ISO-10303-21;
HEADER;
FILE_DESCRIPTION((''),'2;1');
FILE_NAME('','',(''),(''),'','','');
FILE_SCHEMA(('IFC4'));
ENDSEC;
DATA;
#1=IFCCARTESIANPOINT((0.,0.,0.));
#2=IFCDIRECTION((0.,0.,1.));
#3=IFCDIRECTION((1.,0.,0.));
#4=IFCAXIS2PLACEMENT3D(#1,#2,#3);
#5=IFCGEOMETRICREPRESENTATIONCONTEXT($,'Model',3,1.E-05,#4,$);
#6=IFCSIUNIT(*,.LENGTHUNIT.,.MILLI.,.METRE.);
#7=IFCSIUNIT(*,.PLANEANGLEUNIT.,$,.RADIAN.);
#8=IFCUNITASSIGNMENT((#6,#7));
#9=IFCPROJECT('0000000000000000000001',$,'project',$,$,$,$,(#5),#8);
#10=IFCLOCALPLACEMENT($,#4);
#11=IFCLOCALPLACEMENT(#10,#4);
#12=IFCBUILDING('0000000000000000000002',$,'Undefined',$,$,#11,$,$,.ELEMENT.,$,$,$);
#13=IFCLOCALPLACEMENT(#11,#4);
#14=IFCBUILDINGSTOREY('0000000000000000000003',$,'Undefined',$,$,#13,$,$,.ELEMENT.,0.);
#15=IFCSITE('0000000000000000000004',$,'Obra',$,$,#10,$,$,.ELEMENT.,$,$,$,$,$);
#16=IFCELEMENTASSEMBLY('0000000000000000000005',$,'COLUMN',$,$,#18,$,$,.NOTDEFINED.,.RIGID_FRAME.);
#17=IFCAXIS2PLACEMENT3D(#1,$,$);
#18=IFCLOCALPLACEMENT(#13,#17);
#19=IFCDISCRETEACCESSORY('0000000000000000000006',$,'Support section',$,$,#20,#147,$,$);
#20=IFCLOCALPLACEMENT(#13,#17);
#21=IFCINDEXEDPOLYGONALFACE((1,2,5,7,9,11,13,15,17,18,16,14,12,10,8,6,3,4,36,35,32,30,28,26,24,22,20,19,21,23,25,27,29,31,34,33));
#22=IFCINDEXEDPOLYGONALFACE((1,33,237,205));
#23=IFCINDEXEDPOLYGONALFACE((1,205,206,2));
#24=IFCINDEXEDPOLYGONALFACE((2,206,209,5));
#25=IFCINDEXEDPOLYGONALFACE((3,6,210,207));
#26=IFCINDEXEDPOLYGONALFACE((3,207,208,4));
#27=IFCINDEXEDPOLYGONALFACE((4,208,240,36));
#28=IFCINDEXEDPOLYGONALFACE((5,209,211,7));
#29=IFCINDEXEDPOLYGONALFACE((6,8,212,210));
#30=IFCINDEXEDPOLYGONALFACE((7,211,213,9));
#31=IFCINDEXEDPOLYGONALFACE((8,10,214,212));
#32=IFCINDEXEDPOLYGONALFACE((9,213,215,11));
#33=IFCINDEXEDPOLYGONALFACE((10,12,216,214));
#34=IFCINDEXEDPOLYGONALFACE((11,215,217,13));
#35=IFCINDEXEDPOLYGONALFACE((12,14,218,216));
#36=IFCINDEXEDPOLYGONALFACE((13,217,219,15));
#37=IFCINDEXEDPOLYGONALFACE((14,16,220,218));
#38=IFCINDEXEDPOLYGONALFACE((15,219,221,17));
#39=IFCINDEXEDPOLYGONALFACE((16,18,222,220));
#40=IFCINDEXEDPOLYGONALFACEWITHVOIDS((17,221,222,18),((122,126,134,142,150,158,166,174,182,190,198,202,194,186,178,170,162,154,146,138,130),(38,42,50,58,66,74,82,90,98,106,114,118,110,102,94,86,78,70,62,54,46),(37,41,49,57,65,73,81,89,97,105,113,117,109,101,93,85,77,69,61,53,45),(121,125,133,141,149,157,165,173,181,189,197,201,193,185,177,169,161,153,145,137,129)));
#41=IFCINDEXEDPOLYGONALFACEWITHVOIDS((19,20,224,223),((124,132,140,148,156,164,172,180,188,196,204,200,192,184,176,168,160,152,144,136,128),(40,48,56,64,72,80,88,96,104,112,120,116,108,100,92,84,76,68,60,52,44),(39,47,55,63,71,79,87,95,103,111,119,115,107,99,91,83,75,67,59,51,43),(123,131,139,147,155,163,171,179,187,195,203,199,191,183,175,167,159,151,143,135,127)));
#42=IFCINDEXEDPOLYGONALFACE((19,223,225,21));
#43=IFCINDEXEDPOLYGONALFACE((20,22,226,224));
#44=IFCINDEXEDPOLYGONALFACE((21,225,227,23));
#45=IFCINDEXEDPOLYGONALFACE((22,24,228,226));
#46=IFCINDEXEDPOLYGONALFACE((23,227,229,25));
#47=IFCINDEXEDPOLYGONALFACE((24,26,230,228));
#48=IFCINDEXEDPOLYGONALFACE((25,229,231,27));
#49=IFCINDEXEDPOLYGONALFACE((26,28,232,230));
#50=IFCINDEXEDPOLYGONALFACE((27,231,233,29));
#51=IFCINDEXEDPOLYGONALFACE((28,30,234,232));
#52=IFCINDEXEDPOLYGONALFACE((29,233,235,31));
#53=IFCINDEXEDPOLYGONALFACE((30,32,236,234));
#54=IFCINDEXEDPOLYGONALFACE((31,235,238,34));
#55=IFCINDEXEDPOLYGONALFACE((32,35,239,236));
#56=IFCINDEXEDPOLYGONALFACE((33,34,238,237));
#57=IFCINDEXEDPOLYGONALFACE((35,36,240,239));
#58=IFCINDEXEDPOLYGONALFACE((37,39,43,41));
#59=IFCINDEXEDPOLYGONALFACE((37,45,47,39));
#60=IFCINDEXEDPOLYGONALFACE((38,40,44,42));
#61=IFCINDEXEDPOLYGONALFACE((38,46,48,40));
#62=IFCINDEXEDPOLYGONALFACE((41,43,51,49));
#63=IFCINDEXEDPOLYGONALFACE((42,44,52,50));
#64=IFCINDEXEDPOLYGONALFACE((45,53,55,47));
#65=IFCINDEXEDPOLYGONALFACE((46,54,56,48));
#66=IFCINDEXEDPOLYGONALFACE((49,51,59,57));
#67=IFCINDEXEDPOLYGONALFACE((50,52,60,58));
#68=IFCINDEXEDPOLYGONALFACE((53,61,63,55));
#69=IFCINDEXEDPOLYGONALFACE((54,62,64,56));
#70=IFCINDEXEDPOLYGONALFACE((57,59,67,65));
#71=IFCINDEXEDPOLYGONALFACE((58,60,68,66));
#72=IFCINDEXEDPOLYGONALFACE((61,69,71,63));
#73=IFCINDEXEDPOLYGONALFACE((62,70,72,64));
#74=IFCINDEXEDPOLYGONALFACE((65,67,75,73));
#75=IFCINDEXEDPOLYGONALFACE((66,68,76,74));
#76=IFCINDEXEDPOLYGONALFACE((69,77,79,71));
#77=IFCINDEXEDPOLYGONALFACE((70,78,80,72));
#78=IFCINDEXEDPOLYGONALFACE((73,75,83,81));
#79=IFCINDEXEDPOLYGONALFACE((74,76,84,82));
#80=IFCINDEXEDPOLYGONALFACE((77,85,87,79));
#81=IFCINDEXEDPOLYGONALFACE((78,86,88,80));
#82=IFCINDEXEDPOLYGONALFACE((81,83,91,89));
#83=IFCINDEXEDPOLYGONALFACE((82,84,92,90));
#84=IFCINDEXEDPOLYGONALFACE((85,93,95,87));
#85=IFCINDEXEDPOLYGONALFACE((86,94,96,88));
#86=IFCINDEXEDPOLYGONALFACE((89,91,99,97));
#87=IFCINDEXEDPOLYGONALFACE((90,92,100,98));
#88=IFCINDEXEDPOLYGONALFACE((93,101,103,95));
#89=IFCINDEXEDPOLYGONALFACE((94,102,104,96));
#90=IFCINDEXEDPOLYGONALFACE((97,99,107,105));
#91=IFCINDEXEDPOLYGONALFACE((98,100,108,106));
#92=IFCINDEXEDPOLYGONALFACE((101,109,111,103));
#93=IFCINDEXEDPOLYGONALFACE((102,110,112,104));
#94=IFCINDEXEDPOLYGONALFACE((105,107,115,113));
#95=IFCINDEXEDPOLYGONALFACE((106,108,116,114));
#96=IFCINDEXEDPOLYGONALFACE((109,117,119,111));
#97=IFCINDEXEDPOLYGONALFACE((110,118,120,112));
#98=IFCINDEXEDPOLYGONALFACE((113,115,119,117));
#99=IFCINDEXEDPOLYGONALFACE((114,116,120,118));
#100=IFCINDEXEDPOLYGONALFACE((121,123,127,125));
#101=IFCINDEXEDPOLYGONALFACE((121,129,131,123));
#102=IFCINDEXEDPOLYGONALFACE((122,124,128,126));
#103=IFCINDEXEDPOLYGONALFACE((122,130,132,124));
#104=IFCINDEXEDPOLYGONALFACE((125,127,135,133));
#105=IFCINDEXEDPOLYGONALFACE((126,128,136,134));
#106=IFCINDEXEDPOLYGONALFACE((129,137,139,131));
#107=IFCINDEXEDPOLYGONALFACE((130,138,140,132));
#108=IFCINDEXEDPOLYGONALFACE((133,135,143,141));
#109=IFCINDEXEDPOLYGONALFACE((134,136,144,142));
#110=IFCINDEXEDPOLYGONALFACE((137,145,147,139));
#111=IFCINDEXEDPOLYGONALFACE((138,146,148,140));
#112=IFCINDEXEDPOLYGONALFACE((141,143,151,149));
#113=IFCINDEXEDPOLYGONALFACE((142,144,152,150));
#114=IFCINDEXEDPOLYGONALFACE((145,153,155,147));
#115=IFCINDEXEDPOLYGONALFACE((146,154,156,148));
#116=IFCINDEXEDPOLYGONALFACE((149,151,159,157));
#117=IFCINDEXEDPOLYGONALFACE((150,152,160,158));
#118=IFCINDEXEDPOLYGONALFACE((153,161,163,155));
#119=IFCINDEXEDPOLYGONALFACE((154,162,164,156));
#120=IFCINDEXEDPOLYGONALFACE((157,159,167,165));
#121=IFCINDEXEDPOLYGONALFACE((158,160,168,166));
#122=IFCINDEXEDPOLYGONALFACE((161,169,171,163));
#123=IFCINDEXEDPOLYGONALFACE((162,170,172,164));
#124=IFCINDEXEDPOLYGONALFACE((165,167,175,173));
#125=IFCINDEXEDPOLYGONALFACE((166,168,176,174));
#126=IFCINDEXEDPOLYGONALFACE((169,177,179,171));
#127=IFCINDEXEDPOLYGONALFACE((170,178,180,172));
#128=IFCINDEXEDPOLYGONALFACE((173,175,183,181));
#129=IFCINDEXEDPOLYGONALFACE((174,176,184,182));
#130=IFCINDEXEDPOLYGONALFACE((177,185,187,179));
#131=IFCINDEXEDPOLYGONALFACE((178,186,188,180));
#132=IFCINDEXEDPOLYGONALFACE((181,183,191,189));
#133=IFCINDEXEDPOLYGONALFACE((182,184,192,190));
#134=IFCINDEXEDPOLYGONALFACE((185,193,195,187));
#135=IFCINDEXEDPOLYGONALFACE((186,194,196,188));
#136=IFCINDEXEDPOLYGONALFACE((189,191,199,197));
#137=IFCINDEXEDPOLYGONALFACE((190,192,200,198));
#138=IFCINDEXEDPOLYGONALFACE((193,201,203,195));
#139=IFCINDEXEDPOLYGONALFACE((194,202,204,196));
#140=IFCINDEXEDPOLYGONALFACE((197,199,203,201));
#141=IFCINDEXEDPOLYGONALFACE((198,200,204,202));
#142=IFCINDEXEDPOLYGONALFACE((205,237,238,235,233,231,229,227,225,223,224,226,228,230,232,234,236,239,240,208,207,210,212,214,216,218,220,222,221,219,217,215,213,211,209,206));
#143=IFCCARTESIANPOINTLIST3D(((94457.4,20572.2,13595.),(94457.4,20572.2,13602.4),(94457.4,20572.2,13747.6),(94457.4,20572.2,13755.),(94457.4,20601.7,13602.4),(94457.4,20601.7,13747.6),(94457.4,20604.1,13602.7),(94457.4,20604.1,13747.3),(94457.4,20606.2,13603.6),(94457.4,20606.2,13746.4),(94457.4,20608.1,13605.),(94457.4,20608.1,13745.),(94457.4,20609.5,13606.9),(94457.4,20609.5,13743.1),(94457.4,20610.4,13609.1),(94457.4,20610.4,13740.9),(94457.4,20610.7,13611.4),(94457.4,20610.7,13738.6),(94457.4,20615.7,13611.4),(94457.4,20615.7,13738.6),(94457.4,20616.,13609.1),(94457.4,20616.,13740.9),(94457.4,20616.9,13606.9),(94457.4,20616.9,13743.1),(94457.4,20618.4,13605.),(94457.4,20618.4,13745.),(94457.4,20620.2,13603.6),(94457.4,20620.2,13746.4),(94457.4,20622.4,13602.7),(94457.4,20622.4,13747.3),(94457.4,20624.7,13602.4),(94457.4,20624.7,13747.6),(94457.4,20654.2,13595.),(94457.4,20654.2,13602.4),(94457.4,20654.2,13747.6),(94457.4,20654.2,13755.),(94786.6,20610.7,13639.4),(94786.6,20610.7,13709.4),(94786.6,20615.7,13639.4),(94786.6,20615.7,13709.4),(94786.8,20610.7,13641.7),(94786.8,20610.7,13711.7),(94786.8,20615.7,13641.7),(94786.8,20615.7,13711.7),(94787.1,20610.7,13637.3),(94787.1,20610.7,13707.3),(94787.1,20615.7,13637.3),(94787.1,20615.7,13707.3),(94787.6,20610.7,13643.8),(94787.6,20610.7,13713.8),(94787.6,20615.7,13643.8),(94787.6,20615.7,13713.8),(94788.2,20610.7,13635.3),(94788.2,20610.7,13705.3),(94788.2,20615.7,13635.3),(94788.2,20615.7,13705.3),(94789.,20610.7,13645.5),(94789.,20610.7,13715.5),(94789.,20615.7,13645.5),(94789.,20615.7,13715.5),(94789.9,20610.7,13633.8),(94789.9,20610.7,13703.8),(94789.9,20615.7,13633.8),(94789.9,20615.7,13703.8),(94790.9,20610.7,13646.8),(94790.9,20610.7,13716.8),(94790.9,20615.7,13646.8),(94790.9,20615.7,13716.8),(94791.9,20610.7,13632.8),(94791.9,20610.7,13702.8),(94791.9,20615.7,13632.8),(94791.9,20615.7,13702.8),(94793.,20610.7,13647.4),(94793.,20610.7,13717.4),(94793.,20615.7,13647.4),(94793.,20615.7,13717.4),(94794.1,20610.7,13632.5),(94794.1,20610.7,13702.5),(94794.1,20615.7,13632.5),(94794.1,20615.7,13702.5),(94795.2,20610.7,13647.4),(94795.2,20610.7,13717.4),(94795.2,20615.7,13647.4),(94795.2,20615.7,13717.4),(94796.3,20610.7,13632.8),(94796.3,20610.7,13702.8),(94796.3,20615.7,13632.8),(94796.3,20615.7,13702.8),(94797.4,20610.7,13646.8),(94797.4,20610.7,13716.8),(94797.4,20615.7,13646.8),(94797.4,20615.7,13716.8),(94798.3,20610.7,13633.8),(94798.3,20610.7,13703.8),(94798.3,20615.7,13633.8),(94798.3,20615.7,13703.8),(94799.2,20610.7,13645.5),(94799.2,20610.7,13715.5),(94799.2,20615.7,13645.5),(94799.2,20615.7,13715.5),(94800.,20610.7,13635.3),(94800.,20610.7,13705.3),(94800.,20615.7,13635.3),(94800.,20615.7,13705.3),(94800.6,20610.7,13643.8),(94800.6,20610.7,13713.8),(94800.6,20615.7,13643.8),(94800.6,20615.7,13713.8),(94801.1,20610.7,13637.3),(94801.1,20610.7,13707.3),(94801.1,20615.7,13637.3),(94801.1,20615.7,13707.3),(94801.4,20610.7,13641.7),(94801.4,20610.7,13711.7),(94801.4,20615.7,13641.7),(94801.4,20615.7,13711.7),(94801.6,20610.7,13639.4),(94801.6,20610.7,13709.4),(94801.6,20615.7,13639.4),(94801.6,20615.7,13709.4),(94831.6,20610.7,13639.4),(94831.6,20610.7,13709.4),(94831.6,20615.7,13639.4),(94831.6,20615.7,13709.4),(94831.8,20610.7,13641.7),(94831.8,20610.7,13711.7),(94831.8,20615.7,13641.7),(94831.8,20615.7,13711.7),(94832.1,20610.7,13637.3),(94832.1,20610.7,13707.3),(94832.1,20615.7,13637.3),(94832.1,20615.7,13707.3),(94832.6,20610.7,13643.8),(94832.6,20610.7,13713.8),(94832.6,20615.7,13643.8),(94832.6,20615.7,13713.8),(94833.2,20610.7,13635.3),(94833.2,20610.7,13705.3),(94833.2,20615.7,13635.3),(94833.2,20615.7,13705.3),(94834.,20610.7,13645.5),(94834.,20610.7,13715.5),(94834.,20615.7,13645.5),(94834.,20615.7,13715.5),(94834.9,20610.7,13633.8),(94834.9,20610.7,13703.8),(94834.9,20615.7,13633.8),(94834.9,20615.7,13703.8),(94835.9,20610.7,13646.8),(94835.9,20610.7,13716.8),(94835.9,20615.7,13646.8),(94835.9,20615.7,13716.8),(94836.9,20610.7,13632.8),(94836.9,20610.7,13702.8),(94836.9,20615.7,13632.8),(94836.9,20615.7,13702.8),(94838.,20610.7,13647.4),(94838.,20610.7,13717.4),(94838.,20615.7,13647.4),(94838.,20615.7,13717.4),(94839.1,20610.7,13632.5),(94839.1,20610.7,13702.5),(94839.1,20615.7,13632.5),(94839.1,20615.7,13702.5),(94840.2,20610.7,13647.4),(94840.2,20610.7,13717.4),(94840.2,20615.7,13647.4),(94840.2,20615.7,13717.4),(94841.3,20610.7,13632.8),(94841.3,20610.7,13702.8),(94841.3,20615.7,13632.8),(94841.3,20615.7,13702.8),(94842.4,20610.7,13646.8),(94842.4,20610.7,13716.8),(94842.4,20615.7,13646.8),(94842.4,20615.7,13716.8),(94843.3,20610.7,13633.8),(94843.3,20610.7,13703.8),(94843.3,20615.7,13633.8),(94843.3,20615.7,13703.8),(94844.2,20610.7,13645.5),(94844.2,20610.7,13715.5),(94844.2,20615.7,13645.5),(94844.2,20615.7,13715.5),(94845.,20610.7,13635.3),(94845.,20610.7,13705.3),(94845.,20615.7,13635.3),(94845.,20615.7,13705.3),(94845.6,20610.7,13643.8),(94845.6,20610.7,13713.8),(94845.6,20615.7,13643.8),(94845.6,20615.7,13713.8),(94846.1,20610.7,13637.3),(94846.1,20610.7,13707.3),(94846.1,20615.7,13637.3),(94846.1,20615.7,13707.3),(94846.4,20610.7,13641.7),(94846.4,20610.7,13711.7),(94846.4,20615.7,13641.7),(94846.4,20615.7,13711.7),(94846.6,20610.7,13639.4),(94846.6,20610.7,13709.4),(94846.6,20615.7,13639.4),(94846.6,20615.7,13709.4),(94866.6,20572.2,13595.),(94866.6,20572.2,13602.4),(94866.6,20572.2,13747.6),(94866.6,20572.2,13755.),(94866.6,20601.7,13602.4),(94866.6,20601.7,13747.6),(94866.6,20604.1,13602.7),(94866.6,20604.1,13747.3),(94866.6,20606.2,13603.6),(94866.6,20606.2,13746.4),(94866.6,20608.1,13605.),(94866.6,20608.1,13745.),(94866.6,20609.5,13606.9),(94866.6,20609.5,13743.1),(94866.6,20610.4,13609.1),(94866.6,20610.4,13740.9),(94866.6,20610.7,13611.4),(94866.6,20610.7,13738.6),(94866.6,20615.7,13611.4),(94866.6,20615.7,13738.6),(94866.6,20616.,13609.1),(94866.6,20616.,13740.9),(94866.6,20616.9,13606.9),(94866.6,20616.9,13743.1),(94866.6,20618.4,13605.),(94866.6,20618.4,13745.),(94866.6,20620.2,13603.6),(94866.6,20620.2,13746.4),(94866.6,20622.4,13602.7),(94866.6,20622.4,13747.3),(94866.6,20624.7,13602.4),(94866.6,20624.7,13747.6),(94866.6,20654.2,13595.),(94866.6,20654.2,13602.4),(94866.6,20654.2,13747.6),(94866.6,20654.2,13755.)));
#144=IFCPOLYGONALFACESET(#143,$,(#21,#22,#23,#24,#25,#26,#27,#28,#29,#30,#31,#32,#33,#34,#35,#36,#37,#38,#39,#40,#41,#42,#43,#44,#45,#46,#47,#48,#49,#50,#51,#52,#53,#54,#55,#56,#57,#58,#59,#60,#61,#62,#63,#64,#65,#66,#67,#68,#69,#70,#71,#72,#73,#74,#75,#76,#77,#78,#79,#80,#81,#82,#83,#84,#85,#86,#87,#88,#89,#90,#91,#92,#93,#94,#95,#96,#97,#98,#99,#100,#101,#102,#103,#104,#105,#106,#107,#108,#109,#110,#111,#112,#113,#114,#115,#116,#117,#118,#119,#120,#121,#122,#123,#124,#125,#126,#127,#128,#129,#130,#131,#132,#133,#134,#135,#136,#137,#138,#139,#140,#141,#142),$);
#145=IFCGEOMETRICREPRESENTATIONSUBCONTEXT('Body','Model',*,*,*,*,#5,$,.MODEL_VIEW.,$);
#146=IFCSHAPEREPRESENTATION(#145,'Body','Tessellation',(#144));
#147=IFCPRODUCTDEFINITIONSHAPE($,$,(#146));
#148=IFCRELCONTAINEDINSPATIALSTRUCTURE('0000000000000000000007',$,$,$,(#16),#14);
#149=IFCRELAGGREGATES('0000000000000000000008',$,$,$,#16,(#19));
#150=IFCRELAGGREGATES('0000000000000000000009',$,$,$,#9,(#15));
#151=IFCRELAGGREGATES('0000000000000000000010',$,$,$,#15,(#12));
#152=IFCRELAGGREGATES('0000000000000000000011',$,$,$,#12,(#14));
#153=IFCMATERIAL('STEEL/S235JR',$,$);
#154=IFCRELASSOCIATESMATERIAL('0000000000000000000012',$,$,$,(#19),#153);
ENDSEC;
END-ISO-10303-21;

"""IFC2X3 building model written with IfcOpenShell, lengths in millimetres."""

from ifc_helpers import new_model, si_unit, frame, origin_with_axes, origin_2d_with_axis, place, context, subcontext, project, spatial, circle, i_section, extrude, clip, halfspace, source, transform, mapped, material, element, aggregate, save


model = new_model("IFC2X3")

# Units and contexts
model_context = context("Model", 3, precision=1e-05, world=origin_with_axes())
body_context = subcontext(model_context, "Body", "Model", "MODEL_VIEW")
ifc_project = project(units=[si_unit("LENGTHUNIT", "METRE", prefix="MILLI"), si_unit("PLANEANGLEUNIT", "RADIAN")], contexts=[model_context])

# Site, building, storey
site_placement = place(None, origin_with_axes())
site = spatial("IfcSite", under=ifc_project, at=site_placement, Name="Obra", CompositionType="ELEMENT")
building_placement = place(site_placement, origin_with_axes())
building = spatial("IfcBuilding", under=site, at=building_placement, Name="Undefined", CompositionType="ELEMENT")
storey_placement = place(building_placement, origin_with_axes())
storey = spatial("IfcBuildingStorey", under=building, at=storey_placement, Name="Undefined", CompositionType="ELEMENT", Elevation=0.0)

# Element assembly, discrete accessory, opening
assembly_placement = place(storey_placement, origin_with_axes())
assembly = element("IfcElementAssembly", 1, at=assembly_placement, inside=storey, Name="COLUMN", AssemblyPlace="NOTDEFINED", PredefinedType="RIGID_FRAME")
ifc_material_1 = material(Name="STEEL/S235JR")
shared_shape_1 = source(origin_with_axes(), body_context, "Body", "SweptSolid", [
    extrude(circle(Radius=7.5, at=origin_2d_with_axis()), frame((0.0, -2.6, 0.0), z_axis=(0.0, 1.0, 0.0), x_axis=(1.0, 0.0, 0.0)), (0.0, 0.0, 1.0), 5.2),
])
discrete_accessory_1_placement = place(assembly_placement, frame((94458.3, 20613.2, 13675.0), z_axis=(0.0, 0.0, 1.0), x_axis=(1.0, 0.0, 0.0)))
discrete_accessory_1 = element("IfcDiscreteAccessory", 2, at=discrete_accessory_1_placement, material=ifc_material_1, Name="Support section", context=body_context, shape_type="Clipping", body=[
    clip(clip(extrude(i_section(OverallWidth=82.0, OverallDepth=160.0, WebThickness=5.0, FlangeThickness=7.4, FilletRadius=9.0, at=origin_2d_with_axis()), frame((408.3, 0.0, 0.0), z_axis=(-1.0, 0.0, 0.0), x_axis=(0.0, -1.0, 0.0)), (0.0, 0.0, 1.0), 409.2), halfspace(frame((408.3, 0.0, -180.0), z_axis=(-1.0, 0.0, 0.0), x_axis=(0.0, 1.0, 0.0)), True)), halfspace(frame((-0.9, 0.0, 580.0), z_axis=(-1.0, -0.000033, 0.0), x_axis=(0.000033, -1.0, 0.0)), False)),
])
opening_1_placement = place(assembly_placement, frame((94816.6, 20613.2, 13710.0), z_axis=(-1.0, 0.0, 0.0), x_axis=(0.0, 0.0, -1.0)))
element("IfcOpeningElement", 3, at=opening_1_placement, cuts=discrete_accessory_1, ObjectType="Opening", context=body_context, shape_type="MappedRepresentation", body=[
    mapped(shared_shape_1, transform((0.0, 0.0, -22.5))),
    mapped(shared_shape_1, transform((70.0, 0.0, -22.5))),
    mapped(shared_shape_1, transform((0.0, 0.0, 22.5))),
    mapped(shared_shape_1, transform((70.0, 0.0, 22.5))),
])
aggregate(assembly, [discrete_accessory_1])

save(model, "model.ifc")
